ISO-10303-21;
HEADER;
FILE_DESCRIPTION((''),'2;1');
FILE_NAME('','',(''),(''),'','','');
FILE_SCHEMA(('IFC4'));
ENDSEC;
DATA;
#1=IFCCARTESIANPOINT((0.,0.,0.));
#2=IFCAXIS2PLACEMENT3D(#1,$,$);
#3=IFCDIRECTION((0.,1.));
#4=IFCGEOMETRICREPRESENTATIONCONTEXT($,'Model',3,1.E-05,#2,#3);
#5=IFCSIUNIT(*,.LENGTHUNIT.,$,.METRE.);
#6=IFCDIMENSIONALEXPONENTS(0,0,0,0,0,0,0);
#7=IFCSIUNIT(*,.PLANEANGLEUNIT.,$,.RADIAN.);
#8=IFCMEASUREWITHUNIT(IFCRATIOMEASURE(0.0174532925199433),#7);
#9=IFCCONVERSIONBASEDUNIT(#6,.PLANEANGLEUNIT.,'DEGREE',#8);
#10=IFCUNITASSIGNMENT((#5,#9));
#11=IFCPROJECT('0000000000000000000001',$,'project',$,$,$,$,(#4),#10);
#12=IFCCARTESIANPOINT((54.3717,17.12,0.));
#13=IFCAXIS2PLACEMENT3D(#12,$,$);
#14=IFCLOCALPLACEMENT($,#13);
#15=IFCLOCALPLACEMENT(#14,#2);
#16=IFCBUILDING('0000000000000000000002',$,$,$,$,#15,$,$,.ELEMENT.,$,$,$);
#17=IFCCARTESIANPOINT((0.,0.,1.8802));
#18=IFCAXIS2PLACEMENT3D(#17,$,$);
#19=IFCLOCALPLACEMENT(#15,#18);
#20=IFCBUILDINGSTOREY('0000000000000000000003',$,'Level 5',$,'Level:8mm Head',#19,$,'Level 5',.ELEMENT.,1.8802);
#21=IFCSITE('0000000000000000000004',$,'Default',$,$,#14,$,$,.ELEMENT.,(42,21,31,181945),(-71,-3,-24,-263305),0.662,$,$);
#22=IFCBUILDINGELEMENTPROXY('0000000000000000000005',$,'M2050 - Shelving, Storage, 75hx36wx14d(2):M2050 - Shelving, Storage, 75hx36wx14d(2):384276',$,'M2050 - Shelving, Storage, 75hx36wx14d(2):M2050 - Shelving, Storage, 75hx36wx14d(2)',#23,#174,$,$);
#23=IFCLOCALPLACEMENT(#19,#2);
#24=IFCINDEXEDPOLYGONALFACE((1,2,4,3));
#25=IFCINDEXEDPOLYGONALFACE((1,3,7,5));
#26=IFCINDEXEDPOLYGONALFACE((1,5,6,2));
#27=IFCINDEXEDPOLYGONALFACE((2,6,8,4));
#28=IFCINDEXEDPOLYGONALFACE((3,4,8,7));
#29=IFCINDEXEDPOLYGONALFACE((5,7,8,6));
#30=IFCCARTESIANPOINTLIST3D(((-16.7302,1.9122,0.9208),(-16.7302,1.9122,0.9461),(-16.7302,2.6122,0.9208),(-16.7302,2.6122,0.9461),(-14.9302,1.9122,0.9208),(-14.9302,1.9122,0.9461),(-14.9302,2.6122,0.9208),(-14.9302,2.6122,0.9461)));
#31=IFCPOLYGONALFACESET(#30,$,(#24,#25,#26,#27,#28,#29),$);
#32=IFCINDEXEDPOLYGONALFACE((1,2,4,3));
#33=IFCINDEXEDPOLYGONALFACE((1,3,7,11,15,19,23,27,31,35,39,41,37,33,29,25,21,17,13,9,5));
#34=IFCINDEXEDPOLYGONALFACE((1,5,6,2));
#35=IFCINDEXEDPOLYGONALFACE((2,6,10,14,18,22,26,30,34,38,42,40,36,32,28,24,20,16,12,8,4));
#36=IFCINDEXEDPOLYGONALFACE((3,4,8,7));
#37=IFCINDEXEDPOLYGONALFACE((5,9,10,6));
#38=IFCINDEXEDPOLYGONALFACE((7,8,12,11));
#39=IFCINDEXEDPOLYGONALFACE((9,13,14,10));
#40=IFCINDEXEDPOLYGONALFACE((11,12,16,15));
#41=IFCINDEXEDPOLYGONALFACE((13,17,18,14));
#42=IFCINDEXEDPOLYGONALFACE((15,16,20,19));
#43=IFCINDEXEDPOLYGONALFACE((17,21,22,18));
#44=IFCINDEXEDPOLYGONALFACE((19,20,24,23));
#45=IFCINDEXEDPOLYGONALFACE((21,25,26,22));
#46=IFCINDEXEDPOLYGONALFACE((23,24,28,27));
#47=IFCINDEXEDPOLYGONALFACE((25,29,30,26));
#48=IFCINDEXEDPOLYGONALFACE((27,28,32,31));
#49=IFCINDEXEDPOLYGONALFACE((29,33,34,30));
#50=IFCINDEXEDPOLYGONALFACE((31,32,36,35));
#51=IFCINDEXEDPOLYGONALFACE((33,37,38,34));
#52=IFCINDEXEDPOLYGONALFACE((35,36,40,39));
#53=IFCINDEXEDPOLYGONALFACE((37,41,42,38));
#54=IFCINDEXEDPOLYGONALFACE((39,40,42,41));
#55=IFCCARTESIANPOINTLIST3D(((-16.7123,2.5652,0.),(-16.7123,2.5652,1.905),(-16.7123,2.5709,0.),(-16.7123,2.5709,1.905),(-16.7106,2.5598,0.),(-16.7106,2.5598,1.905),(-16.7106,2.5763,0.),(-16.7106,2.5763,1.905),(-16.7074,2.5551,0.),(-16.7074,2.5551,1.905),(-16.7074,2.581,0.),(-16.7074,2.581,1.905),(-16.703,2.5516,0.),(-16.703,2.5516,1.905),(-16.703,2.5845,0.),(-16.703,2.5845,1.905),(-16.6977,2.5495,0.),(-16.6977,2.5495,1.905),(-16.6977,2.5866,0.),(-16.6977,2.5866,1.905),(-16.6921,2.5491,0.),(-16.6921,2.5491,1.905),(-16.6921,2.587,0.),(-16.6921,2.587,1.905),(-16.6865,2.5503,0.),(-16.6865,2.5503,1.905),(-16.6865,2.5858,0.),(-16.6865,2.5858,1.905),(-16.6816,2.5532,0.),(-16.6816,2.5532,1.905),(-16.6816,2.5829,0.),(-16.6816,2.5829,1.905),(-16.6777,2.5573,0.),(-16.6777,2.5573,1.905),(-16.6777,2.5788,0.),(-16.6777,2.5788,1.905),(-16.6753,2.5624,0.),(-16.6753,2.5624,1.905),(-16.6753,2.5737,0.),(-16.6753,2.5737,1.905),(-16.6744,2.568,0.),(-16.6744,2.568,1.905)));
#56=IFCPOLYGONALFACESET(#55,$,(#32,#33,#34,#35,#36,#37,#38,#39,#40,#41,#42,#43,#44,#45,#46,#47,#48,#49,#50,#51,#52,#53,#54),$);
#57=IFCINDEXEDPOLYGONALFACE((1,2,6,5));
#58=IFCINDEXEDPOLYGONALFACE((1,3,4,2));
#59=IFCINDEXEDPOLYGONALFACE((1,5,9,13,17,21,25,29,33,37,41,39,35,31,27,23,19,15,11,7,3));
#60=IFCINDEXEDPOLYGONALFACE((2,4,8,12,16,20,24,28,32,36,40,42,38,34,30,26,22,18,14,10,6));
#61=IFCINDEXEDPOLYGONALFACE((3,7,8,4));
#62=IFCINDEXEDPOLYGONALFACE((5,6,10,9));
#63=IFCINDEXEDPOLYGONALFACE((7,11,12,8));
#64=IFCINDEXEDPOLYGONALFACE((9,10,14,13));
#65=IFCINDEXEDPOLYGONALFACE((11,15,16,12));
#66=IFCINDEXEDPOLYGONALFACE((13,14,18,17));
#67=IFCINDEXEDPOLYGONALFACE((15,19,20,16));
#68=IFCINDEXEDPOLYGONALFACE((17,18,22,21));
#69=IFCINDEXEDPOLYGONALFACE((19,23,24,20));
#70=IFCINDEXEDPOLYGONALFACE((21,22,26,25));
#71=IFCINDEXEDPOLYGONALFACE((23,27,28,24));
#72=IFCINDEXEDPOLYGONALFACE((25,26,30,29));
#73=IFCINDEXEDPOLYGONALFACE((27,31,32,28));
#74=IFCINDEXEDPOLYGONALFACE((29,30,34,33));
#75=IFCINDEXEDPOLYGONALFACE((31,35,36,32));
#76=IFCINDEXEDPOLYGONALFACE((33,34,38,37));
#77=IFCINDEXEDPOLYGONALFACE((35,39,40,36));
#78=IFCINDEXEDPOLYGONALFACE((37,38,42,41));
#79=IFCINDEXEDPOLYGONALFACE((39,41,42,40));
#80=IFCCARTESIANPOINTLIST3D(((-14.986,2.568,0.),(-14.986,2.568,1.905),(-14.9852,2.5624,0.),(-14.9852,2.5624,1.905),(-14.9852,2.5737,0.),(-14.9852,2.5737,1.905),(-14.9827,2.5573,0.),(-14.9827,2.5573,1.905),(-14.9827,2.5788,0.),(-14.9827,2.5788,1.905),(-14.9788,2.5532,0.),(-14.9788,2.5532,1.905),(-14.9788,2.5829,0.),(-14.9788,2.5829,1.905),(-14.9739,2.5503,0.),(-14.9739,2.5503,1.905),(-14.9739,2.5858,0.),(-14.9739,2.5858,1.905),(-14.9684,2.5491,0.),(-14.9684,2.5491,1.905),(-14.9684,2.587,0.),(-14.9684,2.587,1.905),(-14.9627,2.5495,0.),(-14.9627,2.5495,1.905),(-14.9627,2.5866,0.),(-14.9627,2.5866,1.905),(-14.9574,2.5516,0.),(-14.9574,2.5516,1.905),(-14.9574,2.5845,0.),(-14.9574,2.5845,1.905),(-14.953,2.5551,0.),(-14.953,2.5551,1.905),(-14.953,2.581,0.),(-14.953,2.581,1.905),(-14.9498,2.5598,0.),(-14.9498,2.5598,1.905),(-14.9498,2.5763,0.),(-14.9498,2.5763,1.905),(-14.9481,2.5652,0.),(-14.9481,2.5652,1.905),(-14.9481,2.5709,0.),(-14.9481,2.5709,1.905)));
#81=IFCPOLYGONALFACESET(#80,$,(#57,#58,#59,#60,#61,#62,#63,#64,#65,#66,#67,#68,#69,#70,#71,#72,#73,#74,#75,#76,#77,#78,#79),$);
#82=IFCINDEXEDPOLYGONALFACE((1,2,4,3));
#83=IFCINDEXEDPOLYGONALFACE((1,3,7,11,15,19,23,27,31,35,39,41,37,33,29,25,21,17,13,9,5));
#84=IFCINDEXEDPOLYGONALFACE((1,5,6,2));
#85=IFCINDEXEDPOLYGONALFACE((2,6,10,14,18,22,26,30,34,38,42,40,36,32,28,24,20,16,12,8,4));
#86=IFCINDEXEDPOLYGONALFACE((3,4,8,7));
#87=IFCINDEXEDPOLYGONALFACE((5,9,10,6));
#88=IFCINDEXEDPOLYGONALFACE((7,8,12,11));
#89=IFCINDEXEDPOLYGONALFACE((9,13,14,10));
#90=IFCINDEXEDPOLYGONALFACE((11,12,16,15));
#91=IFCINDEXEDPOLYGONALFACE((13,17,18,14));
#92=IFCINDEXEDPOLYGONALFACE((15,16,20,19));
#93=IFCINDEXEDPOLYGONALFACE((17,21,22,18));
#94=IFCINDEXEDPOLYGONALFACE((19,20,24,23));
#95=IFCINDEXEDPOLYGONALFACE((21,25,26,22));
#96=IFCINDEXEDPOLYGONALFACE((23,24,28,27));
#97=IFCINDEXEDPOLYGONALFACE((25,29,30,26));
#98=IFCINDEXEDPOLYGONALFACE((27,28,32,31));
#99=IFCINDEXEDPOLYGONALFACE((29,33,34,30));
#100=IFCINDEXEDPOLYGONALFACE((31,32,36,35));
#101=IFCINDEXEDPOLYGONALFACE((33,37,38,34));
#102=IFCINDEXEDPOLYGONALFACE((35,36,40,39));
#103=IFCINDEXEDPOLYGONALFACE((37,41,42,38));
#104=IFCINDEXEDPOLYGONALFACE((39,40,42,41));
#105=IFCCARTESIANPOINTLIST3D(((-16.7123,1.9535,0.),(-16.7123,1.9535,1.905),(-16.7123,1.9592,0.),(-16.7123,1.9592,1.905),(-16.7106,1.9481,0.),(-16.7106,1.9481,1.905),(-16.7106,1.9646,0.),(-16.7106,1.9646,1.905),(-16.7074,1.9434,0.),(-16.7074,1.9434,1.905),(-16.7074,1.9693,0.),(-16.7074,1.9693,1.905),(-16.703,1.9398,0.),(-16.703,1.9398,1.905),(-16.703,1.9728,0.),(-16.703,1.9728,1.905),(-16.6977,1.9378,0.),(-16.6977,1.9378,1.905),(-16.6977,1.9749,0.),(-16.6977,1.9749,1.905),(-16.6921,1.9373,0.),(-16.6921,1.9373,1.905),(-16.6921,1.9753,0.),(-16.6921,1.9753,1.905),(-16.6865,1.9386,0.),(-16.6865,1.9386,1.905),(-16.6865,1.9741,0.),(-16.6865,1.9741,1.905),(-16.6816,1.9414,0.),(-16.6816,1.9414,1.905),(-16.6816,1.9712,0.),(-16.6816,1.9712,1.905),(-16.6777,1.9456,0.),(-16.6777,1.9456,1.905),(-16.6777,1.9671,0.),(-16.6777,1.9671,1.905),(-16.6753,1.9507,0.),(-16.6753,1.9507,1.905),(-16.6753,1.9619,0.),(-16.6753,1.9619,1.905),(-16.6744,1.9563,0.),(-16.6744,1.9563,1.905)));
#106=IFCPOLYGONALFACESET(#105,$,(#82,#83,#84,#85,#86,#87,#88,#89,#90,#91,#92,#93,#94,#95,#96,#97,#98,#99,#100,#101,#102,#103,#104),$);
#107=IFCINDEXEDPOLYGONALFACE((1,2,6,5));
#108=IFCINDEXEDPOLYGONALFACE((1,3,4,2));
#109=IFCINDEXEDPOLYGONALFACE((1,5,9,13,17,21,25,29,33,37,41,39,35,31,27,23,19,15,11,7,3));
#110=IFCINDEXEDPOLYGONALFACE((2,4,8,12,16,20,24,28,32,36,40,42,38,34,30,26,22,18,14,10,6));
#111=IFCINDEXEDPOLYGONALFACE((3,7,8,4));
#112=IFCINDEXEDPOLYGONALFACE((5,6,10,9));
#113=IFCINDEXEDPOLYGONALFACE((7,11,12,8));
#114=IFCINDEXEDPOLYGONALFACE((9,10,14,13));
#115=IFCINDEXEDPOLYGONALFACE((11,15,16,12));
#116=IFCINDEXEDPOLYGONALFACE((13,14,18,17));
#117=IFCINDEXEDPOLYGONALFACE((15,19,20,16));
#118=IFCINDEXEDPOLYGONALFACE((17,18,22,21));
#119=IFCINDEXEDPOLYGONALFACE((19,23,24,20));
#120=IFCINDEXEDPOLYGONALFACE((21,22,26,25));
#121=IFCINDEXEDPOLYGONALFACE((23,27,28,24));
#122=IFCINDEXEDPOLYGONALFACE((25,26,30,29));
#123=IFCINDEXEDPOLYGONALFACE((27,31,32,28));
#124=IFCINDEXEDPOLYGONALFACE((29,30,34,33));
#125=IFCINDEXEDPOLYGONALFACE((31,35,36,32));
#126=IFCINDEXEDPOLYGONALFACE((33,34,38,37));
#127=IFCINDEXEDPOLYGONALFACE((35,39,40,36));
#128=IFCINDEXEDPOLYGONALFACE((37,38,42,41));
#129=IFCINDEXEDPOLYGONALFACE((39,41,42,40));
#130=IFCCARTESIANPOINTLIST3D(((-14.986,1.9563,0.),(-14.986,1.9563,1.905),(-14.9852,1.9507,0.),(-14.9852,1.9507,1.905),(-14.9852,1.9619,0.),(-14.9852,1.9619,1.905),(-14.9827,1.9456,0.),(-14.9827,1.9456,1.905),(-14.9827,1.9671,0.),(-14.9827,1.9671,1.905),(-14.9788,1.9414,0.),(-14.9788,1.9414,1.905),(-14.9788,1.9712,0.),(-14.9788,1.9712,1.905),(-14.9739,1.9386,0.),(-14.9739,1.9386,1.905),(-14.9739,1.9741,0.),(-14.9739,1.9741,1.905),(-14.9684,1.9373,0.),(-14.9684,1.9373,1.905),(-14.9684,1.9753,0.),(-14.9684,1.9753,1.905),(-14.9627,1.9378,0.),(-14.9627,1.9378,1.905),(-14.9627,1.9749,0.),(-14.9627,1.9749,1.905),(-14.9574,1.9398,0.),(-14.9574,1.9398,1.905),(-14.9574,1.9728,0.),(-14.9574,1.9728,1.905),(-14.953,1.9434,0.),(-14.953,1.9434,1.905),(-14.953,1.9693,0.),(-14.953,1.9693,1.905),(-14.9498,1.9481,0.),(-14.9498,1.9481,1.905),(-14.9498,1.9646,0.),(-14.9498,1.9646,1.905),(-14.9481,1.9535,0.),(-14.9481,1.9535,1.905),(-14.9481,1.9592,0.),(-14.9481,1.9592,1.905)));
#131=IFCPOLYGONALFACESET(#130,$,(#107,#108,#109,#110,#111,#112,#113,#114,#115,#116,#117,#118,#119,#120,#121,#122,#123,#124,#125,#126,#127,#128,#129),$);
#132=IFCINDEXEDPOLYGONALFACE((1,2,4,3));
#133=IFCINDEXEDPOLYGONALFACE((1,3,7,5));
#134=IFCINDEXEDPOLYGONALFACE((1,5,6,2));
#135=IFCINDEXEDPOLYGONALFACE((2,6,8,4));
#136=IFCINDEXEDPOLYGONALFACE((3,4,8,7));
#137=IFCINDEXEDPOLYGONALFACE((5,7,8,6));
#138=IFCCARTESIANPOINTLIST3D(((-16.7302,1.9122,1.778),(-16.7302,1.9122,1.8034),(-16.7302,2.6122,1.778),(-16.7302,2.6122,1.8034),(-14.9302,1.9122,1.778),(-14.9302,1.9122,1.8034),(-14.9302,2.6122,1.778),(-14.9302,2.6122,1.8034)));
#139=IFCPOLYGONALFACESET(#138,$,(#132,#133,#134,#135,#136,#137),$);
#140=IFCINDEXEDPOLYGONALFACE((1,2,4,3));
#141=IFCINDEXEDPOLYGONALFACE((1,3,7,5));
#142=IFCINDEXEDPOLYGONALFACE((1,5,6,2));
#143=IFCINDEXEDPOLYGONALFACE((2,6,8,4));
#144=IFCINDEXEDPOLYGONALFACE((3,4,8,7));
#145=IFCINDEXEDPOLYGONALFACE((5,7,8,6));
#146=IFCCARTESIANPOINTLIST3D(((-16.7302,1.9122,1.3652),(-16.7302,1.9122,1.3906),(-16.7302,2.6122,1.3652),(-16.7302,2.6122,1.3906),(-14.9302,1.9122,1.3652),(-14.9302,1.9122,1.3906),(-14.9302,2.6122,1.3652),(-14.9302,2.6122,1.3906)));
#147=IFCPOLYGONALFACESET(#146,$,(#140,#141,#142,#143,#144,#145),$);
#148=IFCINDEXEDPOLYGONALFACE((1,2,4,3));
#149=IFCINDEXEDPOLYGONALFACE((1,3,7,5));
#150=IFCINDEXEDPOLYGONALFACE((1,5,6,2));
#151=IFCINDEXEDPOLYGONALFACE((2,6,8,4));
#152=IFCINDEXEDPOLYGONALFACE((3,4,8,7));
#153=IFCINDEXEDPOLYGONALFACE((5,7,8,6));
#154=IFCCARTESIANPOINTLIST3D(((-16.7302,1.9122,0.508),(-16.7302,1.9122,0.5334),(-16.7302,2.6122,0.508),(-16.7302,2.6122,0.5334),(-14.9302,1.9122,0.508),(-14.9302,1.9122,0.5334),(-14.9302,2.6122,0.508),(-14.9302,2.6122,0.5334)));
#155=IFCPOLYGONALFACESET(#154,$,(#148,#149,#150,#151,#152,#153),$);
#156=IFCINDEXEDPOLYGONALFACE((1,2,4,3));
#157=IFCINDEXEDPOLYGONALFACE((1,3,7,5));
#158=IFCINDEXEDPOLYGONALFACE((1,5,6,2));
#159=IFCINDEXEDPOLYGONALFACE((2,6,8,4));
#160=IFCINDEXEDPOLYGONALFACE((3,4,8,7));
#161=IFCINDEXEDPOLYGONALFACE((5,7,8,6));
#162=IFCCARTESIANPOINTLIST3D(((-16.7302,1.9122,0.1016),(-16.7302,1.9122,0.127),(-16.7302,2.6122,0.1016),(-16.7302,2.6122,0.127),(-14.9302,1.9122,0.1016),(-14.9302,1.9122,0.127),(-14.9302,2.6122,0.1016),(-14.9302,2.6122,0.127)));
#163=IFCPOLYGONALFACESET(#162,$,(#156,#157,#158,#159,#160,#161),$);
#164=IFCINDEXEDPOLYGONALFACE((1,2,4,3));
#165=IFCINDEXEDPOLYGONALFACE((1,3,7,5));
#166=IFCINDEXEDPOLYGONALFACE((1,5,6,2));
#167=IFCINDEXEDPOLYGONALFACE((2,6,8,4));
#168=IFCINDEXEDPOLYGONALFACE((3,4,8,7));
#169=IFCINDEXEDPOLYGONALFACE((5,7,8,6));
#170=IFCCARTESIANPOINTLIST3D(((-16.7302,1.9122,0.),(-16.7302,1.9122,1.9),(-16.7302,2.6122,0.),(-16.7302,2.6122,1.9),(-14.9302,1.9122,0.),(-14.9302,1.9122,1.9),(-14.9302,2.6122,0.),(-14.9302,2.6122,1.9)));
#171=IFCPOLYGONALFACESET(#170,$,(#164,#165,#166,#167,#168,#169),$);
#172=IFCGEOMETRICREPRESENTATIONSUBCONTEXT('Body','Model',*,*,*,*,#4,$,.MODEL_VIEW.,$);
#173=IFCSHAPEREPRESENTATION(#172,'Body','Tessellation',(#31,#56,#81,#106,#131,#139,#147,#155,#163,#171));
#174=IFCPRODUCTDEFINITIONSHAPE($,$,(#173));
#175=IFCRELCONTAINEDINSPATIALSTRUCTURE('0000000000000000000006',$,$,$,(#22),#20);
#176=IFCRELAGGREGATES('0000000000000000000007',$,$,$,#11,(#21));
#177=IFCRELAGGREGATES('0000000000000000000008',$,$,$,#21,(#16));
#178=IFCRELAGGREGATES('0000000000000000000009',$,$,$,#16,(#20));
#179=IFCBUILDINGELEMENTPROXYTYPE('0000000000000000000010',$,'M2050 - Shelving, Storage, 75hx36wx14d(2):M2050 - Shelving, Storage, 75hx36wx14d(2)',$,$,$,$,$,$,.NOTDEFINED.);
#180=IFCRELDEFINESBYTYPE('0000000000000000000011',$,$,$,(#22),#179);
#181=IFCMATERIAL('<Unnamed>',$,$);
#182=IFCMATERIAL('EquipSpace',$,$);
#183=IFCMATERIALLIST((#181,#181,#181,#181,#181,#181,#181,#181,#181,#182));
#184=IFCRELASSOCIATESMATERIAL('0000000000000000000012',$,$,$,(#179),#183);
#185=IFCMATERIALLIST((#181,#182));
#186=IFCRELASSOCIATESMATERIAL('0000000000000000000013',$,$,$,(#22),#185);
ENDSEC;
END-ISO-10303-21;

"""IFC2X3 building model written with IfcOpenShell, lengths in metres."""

from ifc_helpers import new_model, entity, si_unit, converted_unit, direction, frame, frame_2d, origin, origin_2d_with_axis, place, context, subcontext, project, spatial, rectangle, circle, extrude, source, transform, mapped, material, material_list, type_object, type_shapes, element, save


model = new_model("IFC2X3")

# Units and contexts
model_context = context("Model", 3, precision=1e-05, world=origin(), true_north=direction((0.0, 1.0)))
body_context = subcontext(model_context, "Body", "Model", "MODEL_VIEW")
ifc_project = project(units=[si_unit("LENGTHUNIT", "METRE"), converted_unit("PLANEANGLEUNIT", "DEGREE", entity("IfcRatioMeasure", 0.0174532925199433), si_unit("PLANEANGLEUNIT", "RADIAN"), dimensions=[0, 0, 0, 0, 0, 0, 0])], contexts=[model_context])

# Site, building, storey
site_placement = place(None, frame((54.3717, 17.12, 0.0)))
site = spatial("IfcSite", under=ifc_project, at=site_placement, Name="Default", CompositionType="ELEMENT", RefLatitude=(42, 21, 31, 181945), RefLongitude=(-71, -3, -24, -263305), RefElevation=0.662)
building_placement = place(site_placement, origin())
building = spatial("IfcBuilding", under=site, at=building_placement, CompositionType="ELEMENT")
storey_placement = place(building_placement, frame((0.0, 0.0, 1.8802)))
storey = spatial("IfcBuildingStorey", under=building, at=storey_placement, Name="Level 5", ObjectType="Level:8mm Head", LongName="Level 5", CompositionType="ELEMENT", Elevation=1.8802)

# Building element proxy
ifc_material_1 = material(Name="<Unnamed>")
ifc_material_2 = material(Name="EquipSpace")
ifc_material_list_1 = material_list([ifc_material_1, ifc_material_1, ifc_material_1, ifc_material_1, ifc_material_1, ifc_material_1, ifc_material_1, ifc_material_1, ifc_material_1, ifc_material_2])
building_element_proxy_type = type_object("IfcBuildingElementProxyType", Name="M2050 - Shelving, Storage, 75hx36wx14d(2):M2050 - Shelving, Storage, 75hx36wx14d(2)", PredefinedType="NOTDEFINED", material=ifc_material_list_1)
shared_shape = source(origin(), body_context, "Body", "SweptSolid", [
    extrude(rectangle(XDim=1.8, YDim=0.7, at=origin_2d_with_axis()), frame((0.0, 0.0, 0.9207), z_axis=(0.0, 0.0, 1.0), x_axis=(-1.0, 0.0, 0.0)), (0.0, 0.0, 1.0), 0.0254),
    extrude(circle(Radius=0.0191, at=origin_2d_with_axis()), frame((0.8633, -0.3059, 0.0), z_axis=(0.0, 0.0, 1.0), x_axis=(-1.0, 0.0, 0.0)), (0.0, 0.0, 1.0), 1.905),
    extrude(circle(Radius=0.0191, at=origin_2d_with_axis()), frame((-0.8633, -0.3059, 0.0)), (0.0, 0.0, 1.0), 1.905),
    extrude(circle(Radius=0.0191, at=origin_2d_with_axis()), frame((0.8633, 0.3059, 0.0), z_axis=(0.0, 0.0, 1.0), x_axis=(-1.0, 0.0, 0.0)), (0.0, 0.0, 1.0), 1.905),
    extrude(circle(Radius=0.0191, at=origin_2d_with_axis()), frame((-0.8633, 0.3059, 0.0)), (0.0, 0.0, 1.0), 1.905),
    extrude(rectangle(XDim=1.8, YDim=0.7, at=origin_2d_with_axis()), frame((0.0, 0.0, 1.778), z_axis=(0.0, 0.0, 1.0), x_axis=(-1.0, 0.0, 0.0)), (0.0, 0.0, 1.0), 0.0254),
    extrude(rectangle(XDim=1.8, YDim=0.7, at=origin_2d_with_axis()), frame((0.0, 0.0, 1.3653), z_axis=(0.0, 0.0, 1.0), x_axis=(-1.0, 0.0, 0.0)), (0.0, 0.0, 1.0), 0.0254),
    extrude(rectangle(XDim=1.8, YDim=0.7, at=origin_2d_with_axis()), frame((0.0, 0.0, 0.508), z_axis=(0.0, 0.0, 1.0), x_axis=(-1.0, 0.0, 0.0)), (0.0, 0.0, 1.0), 0.0254),
    extrude(rectangle(XDim=1.8, YDim=0.7, at=origin_2d_with_axis()), frame((0.0, 0.0, 0.1016), z_axis=(0.0, 0.0, 1.0), x_axis=(-1.0, 0.0, 0.0)), (0.0, 0.0, 1.0), 0.0254),
    extrude(rectangle(XDim=0.7, YDim=1.8, at=frame_2d((0.0, 0.18), x_axis=(1.0, 0.0))), frame((-0.18, 0.0, 0.0), z_axis=(0.0, 0.0, 1.0), x_axis=(0.0, -1.0, 0.0)), (0.0, 0.0, 1.0), 1.9),
])
type_shapes(building_element_proxy_type, [shared_shape])
ifc_material_list_2 = material_list([ifc_material_1, ifc_material_2])
proxy_1_placement = place(storey_placement, frame((-15.8302, 2.2622, 0.0), z_axis=(0.0, 0.0, 1.0), x_axis=(-1.0, 0.0, 0.0)))
element("IfcBuildingElementProxy", 1, at=proxy_1_placement, inside=storey, type_object=building_element_proxy_type, material=ifc_material_list_2, Name="M2050 - Shelving, Storage, 75hx36wx14d(2):M2050 - Shelving, Storage, 75hx36wx14d(2):384276", ObjectType="M2050 - Shelving, Storage, 75hx36wx14d(2):M2050 - Shelving, Storage, 75hx36wx14d(2)", context=body_context, shape_type="MappedRepresentation", body=[
    mapped(shared_shape, transform((0.0, 0.0, 0.0), scale=1.0)),
])

save(model, "model.ifc")
